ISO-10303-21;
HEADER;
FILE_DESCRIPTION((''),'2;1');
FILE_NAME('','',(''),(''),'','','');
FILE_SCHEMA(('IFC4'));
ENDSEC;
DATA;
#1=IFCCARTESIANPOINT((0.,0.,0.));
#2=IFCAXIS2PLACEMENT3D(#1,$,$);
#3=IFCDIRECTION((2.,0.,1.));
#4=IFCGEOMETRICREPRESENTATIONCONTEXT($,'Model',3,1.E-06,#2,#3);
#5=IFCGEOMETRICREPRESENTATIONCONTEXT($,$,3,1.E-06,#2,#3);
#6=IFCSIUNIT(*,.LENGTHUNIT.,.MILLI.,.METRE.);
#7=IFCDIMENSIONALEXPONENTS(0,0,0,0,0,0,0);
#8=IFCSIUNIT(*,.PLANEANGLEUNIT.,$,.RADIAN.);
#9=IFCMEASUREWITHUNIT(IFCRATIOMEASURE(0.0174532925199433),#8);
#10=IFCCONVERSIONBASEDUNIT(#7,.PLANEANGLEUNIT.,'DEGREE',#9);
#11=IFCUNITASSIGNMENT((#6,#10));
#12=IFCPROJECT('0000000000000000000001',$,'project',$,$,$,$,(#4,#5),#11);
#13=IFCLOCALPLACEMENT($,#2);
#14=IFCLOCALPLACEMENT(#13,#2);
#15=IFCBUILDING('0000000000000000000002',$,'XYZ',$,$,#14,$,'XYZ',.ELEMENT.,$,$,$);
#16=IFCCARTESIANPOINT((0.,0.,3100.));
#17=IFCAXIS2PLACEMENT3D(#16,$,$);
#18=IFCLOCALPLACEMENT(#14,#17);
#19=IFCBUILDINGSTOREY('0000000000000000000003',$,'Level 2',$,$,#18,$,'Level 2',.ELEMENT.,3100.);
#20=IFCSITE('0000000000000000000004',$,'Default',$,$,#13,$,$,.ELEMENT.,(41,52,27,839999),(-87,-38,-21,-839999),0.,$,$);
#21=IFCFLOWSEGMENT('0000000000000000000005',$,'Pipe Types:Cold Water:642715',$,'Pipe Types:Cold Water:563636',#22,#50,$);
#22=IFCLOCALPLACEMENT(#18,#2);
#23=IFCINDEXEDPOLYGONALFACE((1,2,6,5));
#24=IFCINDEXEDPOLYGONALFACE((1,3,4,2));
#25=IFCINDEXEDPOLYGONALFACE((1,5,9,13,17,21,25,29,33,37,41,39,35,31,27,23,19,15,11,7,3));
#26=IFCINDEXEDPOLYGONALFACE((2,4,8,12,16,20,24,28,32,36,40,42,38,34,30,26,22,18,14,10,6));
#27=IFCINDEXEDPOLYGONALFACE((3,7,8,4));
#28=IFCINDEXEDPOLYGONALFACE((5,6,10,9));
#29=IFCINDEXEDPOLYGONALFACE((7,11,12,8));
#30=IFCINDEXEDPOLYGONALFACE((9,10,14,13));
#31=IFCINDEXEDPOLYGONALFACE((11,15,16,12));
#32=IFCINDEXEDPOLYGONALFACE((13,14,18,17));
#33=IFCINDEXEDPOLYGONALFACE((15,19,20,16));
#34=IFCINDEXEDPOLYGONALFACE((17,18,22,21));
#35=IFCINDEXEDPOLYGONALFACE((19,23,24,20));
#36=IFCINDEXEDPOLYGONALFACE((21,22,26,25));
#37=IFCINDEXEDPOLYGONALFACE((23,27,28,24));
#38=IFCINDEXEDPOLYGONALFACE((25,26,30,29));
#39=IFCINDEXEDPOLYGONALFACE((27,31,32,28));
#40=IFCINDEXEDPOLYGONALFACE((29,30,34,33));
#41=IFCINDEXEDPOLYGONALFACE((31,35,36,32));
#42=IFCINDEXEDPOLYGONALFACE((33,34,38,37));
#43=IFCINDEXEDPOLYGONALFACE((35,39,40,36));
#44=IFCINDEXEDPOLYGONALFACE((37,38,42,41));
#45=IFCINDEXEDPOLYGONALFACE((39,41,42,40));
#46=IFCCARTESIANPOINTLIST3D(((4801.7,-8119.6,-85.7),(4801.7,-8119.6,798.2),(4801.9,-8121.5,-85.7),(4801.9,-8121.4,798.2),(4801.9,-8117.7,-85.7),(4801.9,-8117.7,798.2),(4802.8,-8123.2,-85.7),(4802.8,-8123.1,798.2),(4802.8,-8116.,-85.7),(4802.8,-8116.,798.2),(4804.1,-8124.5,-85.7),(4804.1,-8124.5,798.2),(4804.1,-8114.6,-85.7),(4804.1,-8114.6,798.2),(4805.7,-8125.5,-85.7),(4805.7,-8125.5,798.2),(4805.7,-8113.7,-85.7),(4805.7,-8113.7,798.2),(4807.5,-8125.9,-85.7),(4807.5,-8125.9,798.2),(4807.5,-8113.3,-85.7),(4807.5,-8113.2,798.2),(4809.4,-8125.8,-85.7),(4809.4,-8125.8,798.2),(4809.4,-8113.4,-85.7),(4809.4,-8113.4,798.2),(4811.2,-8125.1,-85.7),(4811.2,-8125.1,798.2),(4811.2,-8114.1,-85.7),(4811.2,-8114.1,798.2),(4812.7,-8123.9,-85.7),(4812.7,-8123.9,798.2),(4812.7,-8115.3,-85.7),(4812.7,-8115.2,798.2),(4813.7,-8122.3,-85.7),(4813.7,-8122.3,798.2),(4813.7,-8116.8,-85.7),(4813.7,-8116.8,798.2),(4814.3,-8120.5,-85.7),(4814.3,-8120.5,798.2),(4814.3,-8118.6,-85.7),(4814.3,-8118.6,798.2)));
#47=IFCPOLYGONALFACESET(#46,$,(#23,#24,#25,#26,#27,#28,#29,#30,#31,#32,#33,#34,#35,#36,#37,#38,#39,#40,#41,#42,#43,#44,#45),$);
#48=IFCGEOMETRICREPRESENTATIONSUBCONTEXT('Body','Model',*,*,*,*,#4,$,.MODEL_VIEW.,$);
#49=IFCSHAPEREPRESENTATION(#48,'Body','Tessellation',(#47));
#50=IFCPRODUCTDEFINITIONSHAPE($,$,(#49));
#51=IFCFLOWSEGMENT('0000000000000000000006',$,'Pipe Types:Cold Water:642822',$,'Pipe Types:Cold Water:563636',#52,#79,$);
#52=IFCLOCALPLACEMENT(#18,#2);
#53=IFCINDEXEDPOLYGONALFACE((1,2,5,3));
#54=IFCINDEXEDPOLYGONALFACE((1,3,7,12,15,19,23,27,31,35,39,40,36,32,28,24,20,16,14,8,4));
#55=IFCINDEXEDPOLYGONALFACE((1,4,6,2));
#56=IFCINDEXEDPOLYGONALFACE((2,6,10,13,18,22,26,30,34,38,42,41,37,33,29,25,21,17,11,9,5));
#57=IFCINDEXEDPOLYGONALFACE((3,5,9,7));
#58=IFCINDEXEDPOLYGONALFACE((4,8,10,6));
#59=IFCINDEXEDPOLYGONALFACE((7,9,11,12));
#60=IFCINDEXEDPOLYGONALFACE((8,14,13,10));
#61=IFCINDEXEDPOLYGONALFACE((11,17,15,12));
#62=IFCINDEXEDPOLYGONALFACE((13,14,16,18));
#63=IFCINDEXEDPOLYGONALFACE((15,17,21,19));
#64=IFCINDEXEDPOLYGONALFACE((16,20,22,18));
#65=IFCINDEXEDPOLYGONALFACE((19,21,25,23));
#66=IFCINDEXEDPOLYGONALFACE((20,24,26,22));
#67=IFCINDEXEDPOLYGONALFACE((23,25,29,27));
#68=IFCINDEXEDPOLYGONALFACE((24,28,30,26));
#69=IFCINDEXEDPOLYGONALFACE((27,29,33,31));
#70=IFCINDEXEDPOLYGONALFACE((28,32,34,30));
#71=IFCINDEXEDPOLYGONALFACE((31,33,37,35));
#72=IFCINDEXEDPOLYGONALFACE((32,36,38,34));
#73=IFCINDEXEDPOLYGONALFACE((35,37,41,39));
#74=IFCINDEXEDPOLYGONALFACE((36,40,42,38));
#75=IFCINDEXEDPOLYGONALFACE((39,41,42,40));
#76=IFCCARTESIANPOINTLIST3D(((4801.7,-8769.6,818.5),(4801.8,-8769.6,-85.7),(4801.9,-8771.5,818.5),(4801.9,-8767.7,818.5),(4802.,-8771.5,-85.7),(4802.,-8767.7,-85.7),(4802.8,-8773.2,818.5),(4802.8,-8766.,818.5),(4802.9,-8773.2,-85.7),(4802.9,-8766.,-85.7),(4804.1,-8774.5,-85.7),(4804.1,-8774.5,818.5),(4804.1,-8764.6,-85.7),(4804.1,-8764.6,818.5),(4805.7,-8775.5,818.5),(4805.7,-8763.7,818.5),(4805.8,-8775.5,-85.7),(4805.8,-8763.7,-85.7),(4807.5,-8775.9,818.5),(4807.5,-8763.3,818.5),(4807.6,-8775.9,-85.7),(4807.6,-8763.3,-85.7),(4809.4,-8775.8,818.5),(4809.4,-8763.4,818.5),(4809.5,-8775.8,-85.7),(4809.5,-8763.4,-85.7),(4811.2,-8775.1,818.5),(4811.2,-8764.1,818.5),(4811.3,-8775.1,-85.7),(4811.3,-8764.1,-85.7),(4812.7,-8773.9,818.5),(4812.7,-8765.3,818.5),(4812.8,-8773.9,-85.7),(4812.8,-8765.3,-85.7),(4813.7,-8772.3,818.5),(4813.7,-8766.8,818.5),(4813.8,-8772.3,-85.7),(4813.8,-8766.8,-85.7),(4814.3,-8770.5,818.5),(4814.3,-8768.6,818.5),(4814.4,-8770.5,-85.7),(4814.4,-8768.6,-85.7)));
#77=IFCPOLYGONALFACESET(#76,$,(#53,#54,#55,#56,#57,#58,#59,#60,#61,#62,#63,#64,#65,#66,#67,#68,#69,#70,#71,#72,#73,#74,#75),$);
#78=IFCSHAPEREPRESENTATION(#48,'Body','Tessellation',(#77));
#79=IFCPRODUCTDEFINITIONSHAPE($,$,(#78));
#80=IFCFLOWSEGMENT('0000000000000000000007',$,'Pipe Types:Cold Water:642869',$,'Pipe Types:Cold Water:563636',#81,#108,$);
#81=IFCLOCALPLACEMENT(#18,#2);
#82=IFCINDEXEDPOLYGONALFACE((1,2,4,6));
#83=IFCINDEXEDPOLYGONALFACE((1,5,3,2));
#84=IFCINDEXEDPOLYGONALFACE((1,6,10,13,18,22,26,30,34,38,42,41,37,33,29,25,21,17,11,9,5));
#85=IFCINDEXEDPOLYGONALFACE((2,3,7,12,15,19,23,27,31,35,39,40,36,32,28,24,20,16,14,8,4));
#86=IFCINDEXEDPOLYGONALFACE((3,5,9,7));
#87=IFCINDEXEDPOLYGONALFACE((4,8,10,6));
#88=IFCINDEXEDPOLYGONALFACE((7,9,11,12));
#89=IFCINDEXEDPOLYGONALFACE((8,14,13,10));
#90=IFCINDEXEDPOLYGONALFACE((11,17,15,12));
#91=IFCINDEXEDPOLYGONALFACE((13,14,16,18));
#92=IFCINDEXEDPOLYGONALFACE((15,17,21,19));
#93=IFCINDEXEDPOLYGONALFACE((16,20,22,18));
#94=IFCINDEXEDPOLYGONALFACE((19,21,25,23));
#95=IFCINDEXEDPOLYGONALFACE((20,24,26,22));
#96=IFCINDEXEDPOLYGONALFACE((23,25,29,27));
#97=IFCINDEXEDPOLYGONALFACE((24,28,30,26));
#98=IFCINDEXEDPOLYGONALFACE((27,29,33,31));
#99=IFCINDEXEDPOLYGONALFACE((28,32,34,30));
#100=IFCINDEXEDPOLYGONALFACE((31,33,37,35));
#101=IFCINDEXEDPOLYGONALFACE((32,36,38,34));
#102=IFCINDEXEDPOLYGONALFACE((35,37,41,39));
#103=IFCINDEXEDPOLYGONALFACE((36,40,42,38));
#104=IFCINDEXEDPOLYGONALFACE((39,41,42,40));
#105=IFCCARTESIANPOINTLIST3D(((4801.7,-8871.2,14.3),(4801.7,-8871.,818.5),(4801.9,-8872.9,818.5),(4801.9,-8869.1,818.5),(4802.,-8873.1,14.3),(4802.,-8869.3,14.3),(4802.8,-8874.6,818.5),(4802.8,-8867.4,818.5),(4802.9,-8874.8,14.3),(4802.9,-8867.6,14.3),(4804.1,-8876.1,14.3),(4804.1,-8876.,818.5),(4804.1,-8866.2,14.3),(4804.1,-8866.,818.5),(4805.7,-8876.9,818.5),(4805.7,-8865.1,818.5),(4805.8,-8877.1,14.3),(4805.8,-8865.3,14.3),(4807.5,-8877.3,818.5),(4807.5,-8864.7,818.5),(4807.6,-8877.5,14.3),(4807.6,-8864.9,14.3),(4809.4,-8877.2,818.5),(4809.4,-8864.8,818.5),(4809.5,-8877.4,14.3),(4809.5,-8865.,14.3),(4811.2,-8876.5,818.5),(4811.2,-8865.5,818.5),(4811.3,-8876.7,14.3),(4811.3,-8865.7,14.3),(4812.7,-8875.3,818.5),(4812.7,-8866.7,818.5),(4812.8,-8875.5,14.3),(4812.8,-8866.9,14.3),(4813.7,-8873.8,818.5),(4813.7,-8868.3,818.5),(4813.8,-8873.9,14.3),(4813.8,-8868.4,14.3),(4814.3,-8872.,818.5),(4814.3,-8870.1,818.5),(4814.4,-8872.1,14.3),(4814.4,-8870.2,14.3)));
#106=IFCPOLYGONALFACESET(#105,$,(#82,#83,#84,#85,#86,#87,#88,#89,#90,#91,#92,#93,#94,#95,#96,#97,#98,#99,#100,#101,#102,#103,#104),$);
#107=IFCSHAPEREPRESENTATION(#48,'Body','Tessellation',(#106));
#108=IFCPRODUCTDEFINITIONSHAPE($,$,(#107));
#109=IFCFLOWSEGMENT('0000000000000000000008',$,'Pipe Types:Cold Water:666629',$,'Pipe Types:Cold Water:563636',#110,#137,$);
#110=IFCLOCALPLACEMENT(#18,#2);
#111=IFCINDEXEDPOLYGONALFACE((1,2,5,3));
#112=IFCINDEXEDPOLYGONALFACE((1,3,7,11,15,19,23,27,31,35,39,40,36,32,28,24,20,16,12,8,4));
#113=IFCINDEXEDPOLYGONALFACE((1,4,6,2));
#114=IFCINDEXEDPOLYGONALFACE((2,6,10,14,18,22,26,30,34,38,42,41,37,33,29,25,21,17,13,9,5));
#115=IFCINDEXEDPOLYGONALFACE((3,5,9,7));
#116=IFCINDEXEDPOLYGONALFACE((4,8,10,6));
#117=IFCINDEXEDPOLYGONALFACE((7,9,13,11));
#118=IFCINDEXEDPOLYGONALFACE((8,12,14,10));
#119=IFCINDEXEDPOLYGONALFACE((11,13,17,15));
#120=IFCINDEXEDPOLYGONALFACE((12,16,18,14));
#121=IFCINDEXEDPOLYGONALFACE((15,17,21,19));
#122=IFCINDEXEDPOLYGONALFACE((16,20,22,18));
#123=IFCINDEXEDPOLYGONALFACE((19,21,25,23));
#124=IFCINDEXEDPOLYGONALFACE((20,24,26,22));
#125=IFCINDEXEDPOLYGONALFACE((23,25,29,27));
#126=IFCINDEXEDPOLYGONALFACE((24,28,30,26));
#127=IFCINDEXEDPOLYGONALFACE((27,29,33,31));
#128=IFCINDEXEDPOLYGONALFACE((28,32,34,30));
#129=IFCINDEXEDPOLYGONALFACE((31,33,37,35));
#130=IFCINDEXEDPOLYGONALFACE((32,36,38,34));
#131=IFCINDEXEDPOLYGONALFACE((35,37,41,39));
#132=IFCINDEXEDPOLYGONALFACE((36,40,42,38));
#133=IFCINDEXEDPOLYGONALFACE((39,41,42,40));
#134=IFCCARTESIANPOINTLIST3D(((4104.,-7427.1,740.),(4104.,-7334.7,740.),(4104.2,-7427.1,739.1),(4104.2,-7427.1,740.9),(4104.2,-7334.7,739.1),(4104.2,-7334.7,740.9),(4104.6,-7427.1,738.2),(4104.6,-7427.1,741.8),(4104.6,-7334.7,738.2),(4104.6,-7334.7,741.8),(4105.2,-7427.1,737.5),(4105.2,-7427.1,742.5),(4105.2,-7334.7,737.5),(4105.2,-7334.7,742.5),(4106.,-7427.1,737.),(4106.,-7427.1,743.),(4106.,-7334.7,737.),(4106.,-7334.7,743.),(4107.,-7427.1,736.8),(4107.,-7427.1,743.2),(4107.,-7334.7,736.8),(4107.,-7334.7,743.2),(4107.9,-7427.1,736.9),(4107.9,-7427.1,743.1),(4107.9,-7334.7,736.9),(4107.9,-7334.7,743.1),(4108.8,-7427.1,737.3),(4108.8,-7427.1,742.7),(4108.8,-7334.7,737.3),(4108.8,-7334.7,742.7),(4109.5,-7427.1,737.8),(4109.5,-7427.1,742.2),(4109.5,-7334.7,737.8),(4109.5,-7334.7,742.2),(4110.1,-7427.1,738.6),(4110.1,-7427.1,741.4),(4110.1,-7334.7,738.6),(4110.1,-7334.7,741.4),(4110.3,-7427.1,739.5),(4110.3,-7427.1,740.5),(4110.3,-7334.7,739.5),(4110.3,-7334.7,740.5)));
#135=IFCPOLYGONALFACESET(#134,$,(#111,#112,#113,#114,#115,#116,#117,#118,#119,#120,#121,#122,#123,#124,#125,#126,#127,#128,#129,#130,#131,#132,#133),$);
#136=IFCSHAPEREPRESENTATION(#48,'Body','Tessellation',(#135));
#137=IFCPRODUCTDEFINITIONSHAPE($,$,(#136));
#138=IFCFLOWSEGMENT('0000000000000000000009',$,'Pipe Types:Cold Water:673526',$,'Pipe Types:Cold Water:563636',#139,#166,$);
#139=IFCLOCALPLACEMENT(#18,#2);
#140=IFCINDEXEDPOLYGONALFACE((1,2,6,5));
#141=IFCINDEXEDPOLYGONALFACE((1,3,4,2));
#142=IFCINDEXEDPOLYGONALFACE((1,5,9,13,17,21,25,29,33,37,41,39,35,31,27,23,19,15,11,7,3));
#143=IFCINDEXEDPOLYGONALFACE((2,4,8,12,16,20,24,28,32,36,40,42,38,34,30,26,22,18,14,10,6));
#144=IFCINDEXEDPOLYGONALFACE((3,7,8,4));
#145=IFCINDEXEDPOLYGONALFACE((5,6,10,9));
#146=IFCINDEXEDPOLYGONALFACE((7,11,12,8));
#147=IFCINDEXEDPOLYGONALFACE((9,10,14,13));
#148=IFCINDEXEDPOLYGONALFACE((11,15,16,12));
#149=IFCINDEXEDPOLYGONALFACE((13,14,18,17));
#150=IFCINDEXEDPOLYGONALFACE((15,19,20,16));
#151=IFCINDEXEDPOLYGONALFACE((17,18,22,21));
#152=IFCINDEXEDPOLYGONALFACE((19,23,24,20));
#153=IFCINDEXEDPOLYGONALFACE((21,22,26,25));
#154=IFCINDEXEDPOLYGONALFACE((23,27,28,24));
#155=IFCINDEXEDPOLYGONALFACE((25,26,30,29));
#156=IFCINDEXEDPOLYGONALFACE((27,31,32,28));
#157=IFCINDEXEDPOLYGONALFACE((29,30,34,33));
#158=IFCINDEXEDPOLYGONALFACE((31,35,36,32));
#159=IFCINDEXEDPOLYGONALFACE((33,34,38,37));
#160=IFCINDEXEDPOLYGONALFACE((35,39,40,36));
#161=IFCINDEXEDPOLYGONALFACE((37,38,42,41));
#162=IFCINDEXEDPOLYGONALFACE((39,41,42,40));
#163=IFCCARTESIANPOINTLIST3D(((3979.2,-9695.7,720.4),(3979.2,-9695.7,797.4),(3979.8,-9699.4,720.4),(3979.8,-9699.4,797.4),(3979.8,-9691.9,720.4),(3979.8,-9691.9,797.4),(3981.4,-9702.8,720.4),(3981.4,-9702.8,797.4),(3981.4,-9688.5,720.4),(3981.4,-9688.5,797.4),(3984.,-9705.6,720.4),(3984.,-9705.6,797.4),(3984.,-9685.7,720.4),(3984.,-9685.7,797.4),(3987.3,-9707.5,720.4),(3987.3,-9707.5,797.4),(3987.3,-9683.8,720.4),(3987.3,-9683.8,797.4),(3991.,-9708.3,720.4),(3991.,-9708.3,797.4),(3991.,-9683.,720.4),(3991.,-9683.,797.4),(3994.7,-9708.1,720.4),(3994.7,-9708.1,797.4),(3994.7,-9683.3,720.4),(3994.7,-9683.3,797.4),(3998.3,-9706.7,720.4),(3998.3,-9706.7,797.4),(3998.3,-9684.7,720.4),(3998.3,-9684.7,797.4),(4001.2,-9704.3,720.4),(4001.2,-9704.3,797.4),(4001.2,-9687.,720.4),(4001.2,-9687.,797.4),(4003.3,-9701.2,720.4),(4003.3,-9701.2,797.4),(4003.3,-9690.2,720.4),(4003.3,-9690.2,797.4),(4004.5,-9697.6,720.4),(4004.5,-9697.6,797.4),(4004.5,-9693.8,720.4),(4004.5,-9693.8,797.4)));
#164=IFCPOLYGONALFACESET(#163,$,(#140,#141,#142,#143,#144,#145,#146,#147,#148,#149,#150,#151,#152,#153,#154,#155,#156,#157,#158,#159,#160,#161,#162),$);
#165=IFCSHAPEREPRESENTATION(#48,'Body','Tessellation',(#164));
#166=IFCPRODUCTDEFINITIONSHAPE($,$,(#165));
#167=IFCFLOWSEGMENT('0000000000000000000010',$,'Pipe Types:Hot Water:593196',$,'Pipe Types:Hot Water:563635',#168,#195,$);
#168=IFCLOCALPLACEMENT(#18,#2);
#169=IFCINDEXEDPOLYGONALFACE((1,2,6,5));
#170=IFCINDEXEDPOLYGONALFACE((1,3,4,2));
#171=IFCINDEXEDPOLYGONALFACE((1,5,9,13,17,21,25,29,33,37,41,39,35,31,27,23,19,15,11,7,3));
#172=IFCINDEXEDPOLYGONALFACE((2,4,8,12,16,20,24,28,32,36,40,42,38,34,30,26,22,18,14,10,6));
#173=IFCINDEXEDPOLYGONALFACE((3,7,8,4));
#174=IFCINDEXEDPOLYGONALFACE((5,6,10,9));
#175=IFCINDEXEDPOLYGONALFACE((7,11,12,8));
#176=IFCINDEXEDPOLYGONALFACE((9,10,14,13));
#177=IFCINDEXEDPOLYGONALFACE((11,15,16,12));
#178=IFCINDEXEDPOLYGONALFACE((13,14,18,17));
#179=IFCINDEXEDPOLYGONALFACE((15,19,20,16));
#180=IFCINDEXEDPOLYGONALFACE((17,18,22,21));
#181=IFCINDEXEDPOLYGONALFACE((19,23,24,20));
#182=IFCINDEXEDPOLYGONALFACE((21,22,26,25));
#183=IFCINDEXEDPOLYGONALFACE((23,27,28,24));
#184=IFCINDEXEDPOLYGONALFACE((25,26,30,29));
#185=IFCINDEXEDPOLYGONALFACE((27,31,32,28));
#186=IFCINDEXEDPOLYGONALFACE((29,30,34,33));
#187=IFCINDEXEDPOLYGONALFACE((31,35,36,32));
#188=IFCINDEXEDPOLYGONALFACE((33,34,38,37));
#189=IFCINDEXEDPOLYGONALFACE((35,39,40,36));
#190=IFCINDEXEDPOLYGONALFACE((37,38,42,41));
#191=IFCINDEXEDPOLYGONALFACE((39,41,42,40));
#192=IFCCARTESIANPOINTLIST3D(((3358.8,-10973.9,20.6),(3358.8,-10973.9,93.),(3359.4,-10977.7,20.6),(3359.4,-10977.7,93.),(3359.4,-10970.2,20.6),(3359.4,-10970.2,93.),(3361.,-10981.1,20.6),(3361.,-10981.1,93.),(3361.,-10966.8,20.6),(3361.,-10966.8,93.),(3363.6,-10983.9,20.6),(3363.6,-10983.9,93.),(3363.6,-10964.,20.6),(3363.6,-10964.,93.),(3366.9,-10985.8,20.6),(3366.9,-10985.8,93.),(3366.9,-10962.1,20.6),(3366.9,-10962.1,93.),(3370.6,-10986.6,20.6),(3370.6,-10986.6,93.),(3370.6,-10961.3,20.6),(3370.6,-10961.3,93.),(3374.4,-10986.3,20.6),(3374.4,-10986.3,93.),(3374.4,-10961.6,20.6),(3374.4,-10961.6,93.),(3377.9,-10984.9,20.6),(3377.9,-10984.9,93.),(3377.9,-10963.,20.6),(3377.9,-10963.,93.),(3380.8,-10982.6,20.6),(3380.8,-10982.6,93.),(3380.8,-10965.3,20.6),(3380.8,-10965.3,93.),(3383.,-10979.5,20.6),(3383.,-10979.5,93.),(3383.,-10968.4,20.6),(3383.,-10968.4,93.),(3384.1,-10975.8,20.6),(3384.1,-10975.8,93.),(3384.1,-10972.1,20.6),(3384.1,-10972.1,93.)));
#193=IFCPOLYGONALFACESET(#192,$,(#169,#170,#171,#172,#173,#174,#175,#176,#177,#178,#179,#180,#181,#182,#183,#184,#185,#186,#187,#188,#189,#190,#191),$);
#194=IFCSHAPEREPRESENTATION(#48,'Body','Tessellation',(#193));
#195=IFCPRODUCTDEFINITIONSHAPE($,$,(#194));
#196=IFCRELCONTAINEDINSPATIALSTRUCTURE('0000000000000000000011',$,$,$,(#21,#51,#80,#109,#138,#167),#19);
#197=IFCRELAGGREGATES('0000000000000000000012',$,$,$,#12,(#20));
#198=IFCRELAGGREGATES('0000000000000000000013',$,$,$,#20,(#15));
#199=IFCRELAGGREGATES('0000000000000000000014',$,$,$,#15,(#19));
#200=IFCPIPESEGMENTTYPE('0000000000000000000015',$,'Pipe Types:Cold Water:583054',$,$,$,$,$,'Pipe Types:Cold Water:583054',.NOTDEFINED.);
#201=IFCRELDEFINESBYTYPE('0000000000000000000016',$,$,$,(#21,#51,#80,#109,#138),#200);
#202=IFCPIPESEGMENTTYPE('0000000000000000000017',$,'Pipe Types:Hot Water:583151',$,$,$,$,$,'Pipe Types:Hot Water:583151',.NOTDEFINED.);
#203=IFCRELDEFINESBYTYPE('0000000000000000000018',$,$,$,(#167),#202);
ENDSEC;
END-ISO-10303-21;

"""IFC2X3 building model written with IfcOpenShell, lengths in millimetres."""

from ifc_helpers import new_model, entity, si_unit, converted_unit, direction, frame, frame_2d, origin, origin_2d_with_axis, place, context, subcontext, project, spatial, circle, extrude, type_object, element, save


model = new_model("IFC2X3")

# Units and contexts
model_context = context("Model", 3, precision=1e-06, world=origin(), true_north=direction((2.0, 0.0, 1.0)))
context_of_model = context(None, 3, precision=1e-06, world=origin(), true_north=direction((2.0, 0.0, 1.0)))
body_context = subcontext(model_context, "Body", "Model", "MODEL_VIEW")
ifc_project = project(units=[si_unit("LENGTHUNIT", "METRE", prefix="MILLI"), converted_unit("PLANEANGLEUNIT", "DEGREE", entity("IfcRatioMeasure", 0.0174532925199433), si_unit("PLANEANGLEUNIT", "RADIAN"), dimensions=[0, 0, 0, 0, 0, 0, 0])], contexts=[model_context, context_of_model])

# Site, building, storey
site_placement = place(None, origin())
site = spatial("IfcSite", under=ifc_project, at=site_placement, Name="Default", CompositionType="ELEMENT", RefLatitude=(41, 52, 27, 839999), RefLongitude=(-87, -38, -21, -839999), RefElevation=0.0)
building_placement = place(site_placement, origin())
building = spatial("IfcBuilding", under=site, at=building_placement, Name="XYZ", LongName="XYZ", CompositionType="ELEMENT")
storey_placement = place(building_placement, frame((0.0, 0.0, 3100.0)))
storey = spatial("IfcBuildingStorey", under=building, at=storey_placement, Name="Level 2", LongName="Level 2", CompositionType="ELEMENT", Elevation=3100.0)

# Flow segments
pipe_segment_type_1 = type_object("IfcPipeSegmentType", Name="Pipe Types:Cold Water:583054", ElementType="Pipe Types:Cold Water:583054", PredefinedType="NOTDEFINED")
flow_segment_1_placement = place(storey_placement, origin())
element("IfcFlowSegment", 1, at=flow_segment_1_placement, inside=storey, type_object=pipe_segment_type_1, Name="Pipe Types:Cold Water:642715", ObjectType="Pipe Types:Cold Water:563636", context=body_context, shape_type="SweptSolid", body=[
    extrude(circle(Radius=6.3, at=origin_2d_with_axis()), frame((4808.0, -8119.6, -85.7), z_axis=(0.0, 0.00002, 1.0), x_axis=(-1.0, 0.0, 0.0)), (0.0, 0.0, 1.0), 883.9),
])
flow_segment_2_placement = place(storey_placement, origin())
element("IfcFlowSegment", 2, at=flow_segment_2_placement, inside=storey, type_object=pipe_segment_type_1, Name="Pipe Types:Cold Water:642822", ObjectType="Pipe Types:Cold Water:563636", context=body_context, shape_type="SweptSolid", body=[
    extrude(circle(Radius=6.3, at=frame_2d((0.0, 0.0), x_axis=(1.0, 0.0))), frame((4808.0, -8769.6, 818.5), z_axis=(0.000097, 0.0, -1.0), x_axis=(-1.0, 0.0, -0.000097)), (0.0, 0.0, 1.0), 904.2),
])
flow_segment_3_placement = place(storey_placement, origin())
element("IfcFlowSegment", 3, at=flow_segment_3_placement, inside=storey, type_object=pipe_segment_type_1, Name="Pipe Types:Cold Water:642869", ObjectType="Pipe Types:Cold Water:563636", context=body_context, shape_type="SweptSolid", body=[
    extrude(circle(Radius=6.3, at=frame_2d((0.0, 0.0), x_axis=(1.0, 0.0))), frame((4808.1, -8871.2, 14.3), z_axis=(-0.000107, 0.000217, 1.0), x_axis=(-1.0, 0.0, -0.000107)), (0.0, 0.0, 1.0), 804.2),
])
flow_segment_4_placement = place(storey_placement, origin())
element("IfcFlowSegment", 4, at=flow_segment_4_placement, inside=storey, type_object=pipe_segment_type_1, Name="Pipe Types:Cold Water:666629", ObjectType="Pipe Types:Cold Water:563636", context=body_context, shape_type="SweptSolid", body=[
    extrude(circle(Radius=3.2, at=frame_2d((0.0, 0.0), x_axis=(1.0, 0.0))), frame((4107.2, -7427.1, 740.0), z_axis=(0.0, 1.0, 0.0), x_axis=(-1.0, 0.0, 0.0)), (0.0, 0.0, 1.0), 92.4),
])
flow_segment_5_placement = place(storey_placement, origin())
element("IfcFlowSegment", 5, at=flow_segment_5_placement, inside=storey, type_object=pipe_segment_type_1, Name="Pipe Types:Cold Water:673526", ObjectType="Pipe Types:Cold Water:563636", context=body_context, shape_type="SweptSolid", body=[
    extrude(circle(Radius=12.7, at=origin_2d_with_axis()), frame((3991.9, -9695.7, 720.4), z_axis=(0.0, 0.0, 1.0), x_axis=(-1.0, 0.0, 0.0)), (0.0, 0.0, 1.0), 77.1),
])
pipe_segment_type_2 = type_object("IfcPipeSegmentType", Name="Pipe Types:Hot Water:583151", ElementType="Pipe Types:Hot Water:583151", PredefinedType="NOTDEFINED")
flow_segment_6_placement = place(storey_placement, origin())
element("IfcFlowSegment", 6, at=flow_segment_6_placement, inside=storey, type_object=pipe_segment_type_2, Name="Pipe Types:Hot Water:593196", ObjectType="Pipe Types:Hot Water:563635", context=body_context, shape_type="SweptSolid", body=[
    extrude(circle(Radius=12.7, at=origin_2d_with_axis()), frame((3371.5, -10973.9, 20.6), z_axis=(0.0, 0.0, 1.0), x_axis=(-1.0, 0.0, 0.0)), (0.0, 0.0, 1.0), 72.4),
])

save(model, "model.ifc")
